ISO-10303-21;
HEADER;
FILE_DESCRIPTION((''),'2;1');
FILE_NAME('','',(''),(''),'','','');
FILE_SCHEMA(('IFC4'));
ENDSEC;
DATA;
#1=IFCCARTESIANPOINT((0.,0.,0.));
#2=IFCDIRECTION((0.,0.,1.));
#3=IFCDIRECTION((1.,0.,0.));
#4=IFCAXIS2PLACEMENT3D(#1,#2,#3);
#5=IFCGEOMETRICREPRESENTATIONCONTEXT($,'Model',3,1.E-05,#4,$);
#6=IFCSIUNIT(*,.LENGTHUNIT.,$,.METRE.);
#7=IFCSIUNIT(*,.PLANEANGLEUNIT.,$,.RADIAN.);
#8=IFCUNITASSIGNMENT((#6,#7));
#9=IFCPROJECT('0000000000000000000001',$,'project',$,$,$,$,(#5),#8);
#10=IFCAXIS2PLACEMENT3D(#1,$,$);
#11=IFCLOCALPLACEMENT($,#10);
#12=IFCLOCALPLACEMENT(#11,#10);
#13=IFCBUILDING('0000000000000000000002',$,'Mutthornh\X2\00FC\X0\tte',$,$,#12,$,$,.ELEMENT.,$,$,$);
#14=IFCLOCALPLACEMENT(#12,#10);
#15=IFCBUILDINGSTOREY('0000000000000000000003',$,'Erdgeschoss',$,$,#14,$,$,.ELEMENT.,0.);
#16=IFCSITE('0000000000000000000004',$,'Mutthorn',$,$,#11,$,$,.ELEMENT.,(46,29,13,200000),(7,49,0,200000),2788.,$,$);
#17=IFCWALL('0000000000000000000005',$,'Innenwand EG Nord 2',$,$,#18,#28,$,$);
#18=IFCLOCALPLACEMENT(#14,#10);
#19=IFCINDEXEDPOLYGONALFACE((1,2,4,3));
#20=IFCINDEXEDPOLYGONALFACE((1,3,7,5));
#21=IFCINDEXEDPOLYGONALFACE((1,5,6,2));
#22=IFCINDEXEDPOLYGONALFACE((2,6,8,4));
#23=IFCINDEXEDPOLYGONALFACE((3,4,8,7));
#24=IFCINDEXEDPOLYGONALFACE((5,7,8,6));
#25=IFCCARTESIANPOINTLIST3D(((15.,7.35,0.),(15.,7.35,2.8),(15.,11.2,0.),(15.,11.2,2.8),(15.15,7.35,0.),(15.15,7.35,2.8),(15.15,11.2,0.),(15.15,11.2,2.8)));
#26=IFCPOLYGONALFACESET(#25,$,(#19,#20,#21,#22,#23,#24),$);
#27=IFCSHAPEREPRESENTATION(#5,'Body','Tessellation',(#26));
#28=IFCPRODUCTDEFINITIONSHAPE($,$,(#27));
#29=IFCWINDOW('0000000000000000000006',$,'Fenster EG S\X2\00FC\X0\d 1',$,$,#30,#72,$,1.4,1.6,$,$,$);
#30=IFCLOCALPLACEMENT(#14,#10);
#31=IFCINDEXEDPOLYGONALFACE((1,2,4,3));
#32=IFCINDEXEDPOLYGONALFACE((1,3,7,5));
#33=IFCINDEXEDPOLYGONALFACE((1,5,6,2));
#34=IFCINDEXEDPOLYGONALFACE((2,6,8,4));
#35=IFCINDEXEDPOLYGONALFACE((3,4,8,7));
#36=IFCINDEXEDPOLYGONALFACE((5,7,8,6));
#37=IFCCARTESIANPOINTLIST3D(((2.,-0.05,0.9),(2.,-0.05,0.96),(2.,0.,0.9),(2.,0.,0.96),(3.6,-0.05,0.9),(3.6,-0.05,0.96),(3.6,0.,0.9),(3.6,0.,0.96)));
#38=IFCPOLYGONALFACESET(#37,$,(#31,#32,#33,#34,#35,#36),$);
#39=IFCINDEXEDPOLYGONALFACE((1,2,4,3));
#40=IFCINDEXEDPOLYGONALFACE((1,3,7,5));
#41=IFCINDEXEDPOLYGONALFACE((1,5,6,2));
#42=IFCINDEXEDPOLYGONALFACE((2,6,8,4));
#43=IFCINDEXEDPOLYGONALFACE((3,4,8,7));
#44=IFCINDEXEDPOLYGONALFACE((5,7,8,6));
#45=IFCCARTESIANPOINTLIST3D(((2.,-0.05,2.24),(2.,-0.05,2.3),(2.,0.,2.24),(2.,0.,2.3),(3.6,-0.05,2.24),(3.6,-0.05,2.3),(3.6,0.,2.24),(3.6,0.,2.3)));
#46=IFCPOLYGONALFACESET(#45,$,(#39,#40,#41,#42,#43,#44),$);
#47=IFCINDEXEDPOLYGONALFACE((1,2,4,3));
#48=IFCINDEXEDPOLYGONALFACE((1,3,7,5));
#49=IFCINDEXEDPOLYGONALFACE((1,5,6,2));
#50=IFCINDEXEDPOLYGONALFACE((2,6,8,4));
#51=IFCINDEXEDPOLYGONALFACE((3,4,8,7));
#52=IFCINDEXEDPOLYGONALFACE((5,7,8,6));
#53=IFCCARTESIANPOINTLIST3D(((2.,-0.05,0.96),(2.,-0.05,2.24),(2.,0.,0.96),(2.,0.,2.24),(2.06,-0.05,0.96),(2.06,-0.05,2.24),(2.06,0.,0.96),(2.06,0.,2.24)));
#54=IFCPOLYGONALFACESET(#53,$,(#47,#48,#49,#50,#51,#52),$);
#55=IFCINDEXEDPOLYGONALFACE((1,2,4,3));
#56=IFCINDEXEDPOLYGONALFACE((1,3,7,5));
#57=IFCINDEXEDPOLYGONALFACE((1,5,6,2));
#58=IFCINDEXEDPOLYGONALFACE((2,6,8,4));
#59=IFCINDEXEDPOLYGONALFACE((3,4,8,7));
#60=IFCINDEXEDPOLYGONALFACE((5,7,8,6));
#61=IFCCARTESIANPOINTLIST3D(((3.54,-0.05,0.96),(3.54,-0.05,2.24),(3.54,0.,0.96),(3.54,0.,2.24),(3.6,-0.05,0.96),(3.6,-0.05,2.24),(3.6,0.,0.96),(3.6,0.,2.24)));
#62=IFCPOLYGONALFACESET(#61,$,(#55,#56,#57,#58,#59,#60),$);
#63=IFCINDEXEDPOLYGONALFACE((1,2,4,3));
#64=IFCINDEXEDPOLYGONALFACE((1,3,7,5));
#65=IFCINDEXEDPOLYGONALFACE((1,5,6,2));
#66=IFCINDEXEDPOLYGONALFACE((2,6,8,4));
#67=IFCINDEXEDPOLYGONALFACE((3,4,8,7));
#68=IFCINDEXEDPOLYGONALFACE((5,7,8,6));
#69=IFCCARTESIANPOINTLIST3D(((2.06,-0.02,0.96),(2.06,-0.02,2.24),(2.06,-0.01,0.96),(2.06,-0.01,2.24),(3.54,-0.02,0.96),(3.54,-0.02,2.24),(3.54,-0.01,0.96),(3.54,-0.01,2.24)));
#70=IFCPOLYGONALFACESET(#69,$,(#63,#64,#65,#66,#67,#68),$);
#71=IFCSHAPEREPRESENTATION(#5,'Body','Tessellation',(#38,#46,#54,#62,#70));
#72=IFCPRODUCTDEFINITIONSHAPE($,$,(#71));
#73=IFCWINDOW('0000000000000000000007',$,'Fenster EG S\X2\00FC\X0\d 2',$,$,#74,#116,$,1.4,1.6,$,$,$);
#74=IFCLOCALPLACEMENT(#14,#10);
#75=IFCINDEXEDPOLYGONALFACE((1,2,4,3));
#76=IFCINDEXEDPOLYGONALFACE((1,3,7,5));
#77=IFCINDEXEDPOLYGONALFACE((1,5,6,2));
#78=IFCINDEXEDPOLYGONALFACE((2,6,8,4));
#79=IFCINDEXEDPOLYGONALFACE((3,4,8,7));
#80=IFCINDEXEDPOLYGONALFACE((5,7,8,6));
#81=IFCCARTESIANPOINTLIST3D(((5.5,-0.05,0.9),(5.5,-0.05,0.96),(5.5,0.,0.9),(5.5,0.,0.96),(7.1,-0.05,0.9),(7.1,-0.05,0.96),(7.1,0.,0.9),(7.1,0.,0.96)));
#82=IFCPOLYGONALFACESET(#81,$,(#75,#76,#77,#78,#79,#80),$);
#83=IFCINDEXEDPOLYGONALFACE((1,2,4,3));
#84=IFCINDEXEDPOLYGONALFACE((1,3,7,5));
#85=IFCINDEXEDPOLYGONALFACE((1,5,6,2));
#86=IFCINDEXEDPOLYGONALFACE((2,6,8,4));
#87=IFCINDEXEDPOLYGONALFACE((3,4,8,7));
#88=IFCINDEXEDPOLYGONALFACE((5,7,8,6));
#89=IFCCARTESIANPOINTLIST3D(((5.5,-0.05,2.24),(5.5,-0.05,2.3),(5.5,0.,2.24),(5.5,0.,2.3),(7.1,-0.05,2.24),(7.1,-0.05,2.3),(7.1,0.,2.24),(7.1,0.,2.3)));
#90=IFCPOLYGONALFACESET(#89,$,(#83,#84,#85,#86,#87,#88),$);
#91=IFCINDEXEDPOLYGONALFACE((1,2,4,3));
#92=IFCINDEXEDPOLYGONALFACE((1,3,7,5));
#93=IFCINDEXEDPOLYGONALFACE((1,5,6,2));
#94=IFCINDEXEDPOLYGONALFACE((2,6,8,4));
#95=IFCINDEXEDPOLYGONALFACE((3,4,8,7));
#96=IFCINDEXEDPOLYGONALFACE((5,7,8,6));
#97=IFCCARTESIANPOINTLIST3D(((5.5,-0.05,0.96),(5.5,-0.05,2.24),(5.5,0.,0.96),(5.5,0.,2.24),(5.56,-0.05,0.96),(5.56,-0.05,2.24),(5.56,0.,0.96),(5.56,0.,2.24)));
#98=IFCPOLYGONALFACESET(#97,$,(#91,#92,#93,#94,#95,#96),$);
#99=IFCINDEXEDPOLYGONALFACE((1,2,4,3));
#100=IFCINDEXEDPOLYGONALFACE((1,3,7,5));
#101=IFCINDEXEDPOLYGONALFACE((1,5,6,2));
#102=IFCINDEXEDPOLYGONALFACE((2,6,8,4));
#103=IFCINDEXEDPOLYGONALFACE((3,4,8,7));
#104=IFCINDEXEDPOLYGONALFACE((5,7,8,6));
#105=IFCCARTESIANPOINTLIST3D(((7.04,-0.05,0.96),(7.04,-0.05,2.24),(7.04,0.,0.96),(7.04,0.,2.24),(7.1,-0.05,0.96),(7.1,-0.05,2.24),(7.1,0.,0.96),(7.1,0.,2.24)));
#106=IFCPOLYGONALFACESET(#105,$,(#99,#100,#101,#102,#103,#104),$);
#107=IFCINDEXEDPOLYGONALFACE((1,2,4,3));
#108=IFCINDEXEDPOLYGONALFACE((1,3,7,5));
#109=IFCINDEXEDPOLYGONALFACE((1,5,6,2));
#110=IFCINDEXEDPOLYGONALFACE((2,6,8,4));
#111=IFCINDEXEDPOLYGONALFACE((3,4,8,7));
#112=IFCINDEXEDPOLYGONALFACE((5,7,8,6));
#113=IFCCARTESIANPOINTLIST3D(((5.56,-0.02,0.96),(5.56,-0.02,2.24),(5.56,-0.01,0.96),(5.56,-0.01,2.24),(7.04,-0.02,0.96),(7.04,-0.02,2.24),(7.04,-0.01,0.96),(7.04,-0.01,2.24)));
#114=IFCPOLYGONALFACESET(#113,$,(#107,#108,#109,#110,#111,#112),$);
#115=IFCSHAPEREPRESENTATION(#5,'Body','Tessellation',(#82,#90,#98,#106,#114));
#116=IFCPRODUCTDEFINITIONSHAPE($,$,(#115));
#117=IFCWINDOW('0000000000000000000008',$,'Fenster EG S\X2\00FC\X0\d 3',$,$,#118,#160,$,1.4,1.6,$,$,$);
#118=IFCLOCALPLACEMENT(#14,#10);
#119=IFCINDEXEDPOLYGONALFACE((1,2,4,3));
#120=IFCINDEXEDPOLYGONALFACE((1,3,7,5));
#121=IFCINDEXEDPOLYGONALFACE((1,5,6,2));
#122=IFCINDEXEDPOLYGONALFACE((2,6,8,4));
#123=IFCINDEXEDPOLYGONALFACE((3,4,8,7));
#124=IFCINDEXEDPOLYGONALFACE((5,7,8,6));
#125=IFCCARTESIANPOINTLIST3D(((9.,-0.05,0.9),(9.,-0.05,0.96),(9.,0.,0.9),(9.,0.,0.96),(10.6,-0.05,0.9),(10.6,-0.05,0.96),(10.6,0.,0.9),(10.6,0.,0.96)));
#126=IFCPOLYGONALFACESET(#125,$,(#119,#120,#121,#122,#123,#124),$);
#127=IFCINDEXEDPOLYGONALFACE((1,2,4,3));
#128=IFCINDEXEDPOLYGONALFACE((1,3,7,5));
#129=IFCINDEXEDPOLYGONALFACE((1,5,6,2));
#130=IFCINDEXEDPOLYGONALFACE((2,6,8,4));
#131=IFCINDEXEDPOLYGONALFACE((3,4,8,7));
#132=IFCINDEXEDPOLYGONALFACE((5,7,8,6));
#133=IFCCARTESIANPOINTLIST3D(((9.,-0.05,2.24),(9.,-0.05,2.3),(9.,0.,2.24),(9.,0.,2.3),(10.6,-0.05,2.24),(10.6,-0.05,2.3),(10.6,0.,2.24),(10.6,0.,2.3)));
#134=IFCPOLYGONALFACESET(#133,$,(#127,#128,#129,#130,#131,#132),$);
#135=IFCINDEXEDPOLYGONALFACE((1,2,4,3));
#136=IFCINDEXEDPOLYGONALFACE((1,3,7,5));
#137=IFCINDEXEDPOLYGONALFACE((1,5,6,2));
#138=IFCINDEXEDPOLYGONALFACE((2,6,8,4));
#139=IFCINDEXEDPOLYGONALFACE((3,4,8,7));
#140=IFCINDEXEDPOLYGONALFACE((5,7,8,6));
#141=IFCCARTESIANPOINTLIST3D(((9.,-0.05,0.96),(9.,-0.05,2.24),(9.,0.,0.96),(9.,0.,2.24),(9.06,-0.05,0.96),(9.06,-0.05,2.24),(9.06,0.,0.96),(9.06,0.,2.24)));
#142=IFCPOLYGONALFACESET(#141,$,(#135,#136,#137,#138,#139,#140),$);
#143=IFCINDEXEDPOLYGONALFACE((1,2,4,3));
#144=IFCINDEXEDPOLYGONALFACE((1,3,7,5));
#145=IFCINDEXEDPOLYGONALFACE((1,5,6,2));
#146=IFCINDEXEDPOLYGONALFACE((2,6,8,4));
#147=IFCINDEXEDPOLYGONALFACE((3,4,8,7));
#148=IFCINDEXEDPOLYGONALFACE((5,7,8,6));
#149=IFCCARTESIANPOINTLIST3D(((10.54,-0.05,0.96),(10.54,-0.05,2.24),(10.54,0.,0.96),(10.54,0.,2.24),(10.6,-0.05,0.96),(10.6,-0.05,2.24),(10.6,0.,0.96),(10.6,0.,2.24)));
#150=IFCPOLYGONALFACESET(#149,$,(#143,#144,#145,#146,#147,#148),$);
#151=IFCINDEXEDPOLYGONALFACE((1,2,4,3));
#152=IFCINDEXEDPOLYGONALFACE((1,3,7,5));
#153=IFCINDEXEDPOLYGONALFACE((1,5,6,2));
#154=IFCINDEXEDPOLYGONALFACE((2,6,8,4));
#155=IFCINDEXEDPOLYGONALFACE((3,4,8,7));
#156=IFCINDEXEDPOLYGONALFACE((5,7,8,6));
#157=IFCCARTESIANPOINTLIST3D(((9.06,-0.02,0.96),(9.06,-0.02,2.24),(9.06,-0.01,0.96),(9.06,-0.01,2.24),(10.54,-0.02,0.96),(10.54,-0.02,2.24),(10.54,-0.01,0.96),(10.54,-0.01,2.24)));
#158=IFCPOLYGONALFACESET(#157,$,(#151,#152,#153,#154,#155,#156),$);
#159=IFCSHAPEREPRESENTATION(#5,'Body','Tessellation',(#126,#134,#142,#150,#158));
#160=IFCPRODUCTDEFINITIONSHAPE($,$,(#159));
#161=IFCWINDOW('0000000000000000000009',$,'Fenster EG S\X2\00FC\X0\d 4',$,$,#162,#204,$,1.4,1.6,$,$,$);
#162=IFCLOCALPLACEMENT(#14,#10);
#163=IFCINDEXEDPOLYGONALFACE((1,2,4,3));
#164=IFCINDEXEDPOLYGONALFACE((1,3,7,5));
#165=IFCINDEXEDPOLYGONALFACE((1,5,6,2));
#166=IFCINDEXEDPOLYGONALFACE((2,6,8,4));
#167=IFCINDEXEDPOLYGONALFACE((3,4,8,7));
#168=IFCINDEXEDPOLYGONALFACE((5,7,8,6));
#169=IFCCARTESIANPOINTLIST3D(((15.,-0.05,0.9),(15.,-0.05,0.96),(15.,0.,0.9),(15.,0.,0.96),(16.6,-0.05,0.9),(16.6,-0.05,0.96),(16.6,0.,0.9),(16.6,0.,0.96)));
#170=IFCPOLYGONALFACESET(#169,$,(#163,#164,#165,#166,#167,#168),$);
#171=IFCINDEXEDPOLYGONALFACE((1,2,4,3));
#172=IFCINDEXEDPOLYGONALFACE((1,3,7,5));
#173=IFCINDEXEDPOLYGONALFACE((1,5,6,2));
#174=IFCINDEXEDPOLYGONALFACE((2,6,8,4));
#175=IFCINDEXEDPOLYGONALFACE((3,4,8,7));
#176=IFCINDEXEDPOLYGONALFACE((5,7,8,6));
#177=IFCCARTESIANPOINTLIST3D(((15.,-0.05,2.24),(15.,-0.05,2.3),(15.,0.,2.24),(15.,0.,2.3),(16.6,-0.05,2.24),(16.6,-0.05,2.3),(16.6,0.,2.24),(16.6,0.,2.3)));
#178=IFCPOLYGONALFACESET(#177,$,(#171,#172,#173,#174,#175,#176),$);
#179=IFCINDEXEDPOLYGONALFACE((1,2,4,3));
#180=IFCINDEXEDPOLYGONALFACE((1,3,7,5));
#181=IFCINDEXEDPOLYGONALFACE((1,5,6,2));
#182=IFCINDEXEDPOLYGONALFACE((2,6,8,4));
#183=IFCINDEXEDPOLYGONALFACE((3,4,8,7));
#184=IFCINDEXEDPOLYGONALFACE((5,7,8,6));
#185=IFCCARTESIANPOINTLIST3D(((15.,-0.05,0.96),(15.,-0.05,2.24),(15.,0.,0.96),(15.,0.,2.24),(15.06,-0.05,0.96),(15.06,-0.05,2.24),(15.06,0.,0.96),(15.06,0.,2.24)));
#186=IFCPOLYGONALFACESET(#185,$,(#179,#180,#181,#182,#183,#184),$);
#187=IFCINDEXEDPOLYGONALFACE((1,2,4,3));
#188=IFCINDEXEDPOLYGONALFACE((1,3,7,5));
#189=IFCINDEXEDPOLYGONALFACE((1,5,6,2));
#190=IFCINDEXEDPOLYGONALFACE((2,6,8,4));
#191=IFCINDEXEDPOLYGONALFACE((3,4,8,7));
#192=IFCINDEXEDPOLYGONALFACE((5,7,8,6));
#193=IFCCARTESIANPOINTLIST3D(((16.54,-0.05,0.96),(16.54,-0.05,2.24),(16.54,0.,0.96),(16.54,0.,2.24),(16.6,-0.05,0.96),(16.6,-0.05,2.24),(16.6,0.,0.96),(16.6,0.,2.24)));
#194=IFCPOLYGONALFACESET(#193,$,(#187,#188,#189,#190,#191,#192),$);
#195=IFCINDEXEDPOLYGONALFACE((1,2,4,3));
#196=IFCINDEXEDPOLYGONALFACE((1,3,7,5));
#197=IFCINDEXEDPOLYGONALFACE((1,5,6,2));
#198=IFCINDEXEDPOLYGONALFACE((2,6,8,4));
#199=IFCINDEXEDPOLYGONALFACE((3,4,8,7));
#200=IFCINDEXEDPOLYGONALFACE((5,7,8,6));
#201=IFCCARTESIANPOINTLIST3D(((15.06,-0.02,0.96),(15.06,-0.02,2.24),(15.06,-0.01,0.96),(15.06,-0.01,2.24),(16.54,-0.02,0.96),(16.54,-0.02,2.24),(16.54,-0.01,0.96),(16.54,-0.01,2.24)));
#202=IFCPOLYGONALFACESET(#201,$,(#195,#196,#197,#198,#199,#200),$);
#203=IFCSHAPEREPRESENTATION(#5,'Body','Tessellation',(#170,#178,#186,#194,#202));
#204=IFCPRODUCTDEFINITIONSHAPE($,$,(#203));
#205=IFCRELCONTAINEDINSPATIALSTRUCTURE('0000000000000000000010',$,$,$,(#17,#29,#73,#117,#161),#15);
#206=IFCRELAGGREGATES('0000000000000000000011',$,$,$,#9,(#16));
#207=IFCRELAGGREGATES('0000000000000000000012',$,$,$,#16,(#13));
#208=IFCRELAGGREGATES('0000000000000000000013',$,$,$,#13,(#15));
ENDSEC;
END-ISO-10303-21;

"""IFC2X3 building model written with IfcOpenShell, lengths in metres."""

from ifc_helpers import new_model, si_unit, frame, frame_2d, origin, origin_with_axes, place, context, project, spatial, rectangle, extrude, element, save


model = new_model("IFC2X3")

# Units and contexts
model_context = context("Model", 3, precision=1e-05, world=origin_with_axes())
ifc_project = project(units=[si_unit("LENGTHUNIT", "METRE"), si_unit("PLANEANGLEUNIT", "RADIAN")], contexts=[model_context])

# Site, building, storey
site_placement = place(None, origin())
site = spatial("IfcSite", under=ifc_project, at=site_placement, Name="Mutthorn", CompositionType="ELEMENT", RefLatitude=(46, 29, 13, 200000), RefLongitude=(7, 49, 0, 200000), RefElevation=2788.0)
building_placement = place(site_placement, origin())
building = spatial("IfcBuilding", under=site, at=building_placement, Name="Mutthornhütte", CompositionType="ELEMENT")
storey_placement = place(building_placement, origin())
storey = spatial("IfcBuildingStorey", under=building, at=storey_placement, Name="Erdgeschoss", CompositionType="ELEMENT", Elevation=0.0)

# Wall
wall_1_placement = place(storey_placement, origin())
element("IfcWall", 1, at=wall_1_placement, inside=storey, Name="Innenwand EG Nord 2", context=model_context, shape_type="SweptSolid", body=[
    extrude(rectangle(XDim=0.15, YDim=3.85, at=frame_2d((0.075, 1.925))), frame((15.0, 7.35, 0.0)), (0.0, 0.0, 1.0), 2.8),
])

# Windows
window_1_placement = place(storey_placement, origin())
element("IfcWindow", 2, at=window_1_placement, inside=storey, Name="Fenster EG Süd 1", OverallHeight=1.4, OverallWidth=1.6, context=model_context, shape_type="SweptSolid", body=[
    extrude(rectangle(XDim=1.6, YDim=0.05, at=frame_2d((0.8, 0.025))), frame((2.0, -0.05, 0.9)), (0.0, 0.0, 1.0), 0.06),
    extrude(rectangle(XDim=1.6, YDim=0.05, at=frame_2d((0.8, 0.025))), frame((2.0, -0.05, 2.24)), (0.0, 0.0, 1.0), 0.06),
    extrude(rectangle(XDim=0.06, YDim=0.05, at=frame_2d((0.03, 0.025))), frame((2.0, -0.05, 0.96)), (0.0, 0.0, 1.0), 1.28),
    extrude(rectangle(XDim=0.06, YDim=0.05, at=frame_2d((0.03, 0.025))), frame((3.54, -0.05, 0.96)), (0.0, 0.0, 1.0), 1.28),
    extrude(rectangle(XDim=1.48, YDim=0.01, at=frame_2d((0.74, 0.005))), frame((2.06, -0.02, 0.96)), (0.0, 0.0, 1.0), 1.28),
])
window_2_placement = place(storey_placement, origin())
element("IfcWindow", 3, at=window_2_placement, inside=storey, Name="Fenster EG Süd 2", OverallHeight=1.4, OverallWidth=1.6, context=model_context, shape_type="SweptSolid", body=[
    extrude(rectangle(XDim=1.6, YDim=0.05, at=frame_2d((0.8, 0.025))), frame((5.5, -0.05, 0.9)), (0.0, 0.0, 1.0), 0.06),
    extrude(rectangle(XDim=1.6, YDim=0.05, at=frame_2d((0.8, 0.025))), frame((5.5, -0.05, 2.24)), (0.0, 0.0, 1.0), 0.06),
    extrude(rectangle(XDim=0.06, YDim=0.05, at=frame_2d((0.03, 0.025))), frame((5.5, -0.05, 0.96)), (0.0, 0.0, 1.0), 1.28),
    extrude(rectangle(XDim=0.06, YDim=0.05, at=frame_2d((0.03, 0.025))), frame((7.04, -0.05, 0.96)), (0.0, 0.0, 1.0), 1.28),
    extrude(rectangle(XDim=1.48, YDim=0.01, at=frame_2d((0.74, 0.005))), frame((5.56, -0.02, 0.96)), (0.0, 0.0, 1.0), 1.28),
])
window_3_placement = place(storey_placement, origin())
element("IfcWindow", 4, at=window_3_placement, inside=storey, Name="Fenster EG Süd 3", OverallHeight=1.4, OverallWidth=1.6, context=model_context, shape_type="SweptSolid", body=[
    extrude(rectangle(XDim=1.6, YDim=0.05, at=frame_2d((0.8, 0.025))), frame((9.0, -0.05, 0.9)), (0.0, 0.0, 1.0), 0.06),
    extrude(rectangle(XDim=1.6, YDim=0.05, at=frame_2d((0.8, 0.025))), frame((9.0, -0.05, 2.24)), (0.0, 0.0, 1.0), 0.06),
    extrude(rectangle(XDim=0.06, YDim=0.05, at=frame_2d((0.03, 0.025))), frame((9.0, -0.05, 0.96)), (0.0, 0.0, 1.0), 1.28),
    extrude(rectangle(XDim=0.06, YDim=0.05, at=frame_2d((0.03, 0.025))), frame((10.54, -0.05, 0.96)), (0.0, 0.0, 1.0), 1.28),
    extrude(rectangle(XDim=1.48, YDim=0.01, at=frame_2d((0.74, 0.005))), frame((9.06, -0.02, 0.96)), (0.0, 0.0, 1.0), 1.28),
])
window_4_placement = place(storey_placement, origin())
element("IfcWindow", 5, at=window_4_placement, inside=storey, Name="Fenster EG Süd 4", OverallHeight=1.4, OverallWidth=1.6, context=model_context, shape_type="SweptSolid", body=[
    extrude(rectangle(XDim=1.6, YDim=0.05, at=frame_2d((0.8, 0.025))), frame((15.0, -0.05, 0.9)), (0.0, 0.0, 1.0), 0.06),
    extrude(rectangle(XDim=1.6, YDim=0.05, at=frame_2d((0.8, 0.025))), frame((15.0, -0.05, 2.24)), (0.0, 0.0, 1.0), 0.06),
    extrude(rectangle(XDim=0.06, YDim=0.05, at=frame_2d((0.03, 0.025))), frame((15.0, -0.05, 0.96)), (0.0, 0.0, 1.0), 1.28),
    extrude(rectangle(XDim=0.06, YDim=0.05, at=frame_2d((0.03, 0.025))), frame((16.54, -0.05, 0.96)), (0.0, 0.0, 1.0), 1.28),
    extrude(rectangle(XDim=1.48, YDim=0.01, at=frame_2d((0.74, 0.005))), frame((15.06, -0.02, 0.96)), (0.0, 0.0, 1.0), 1.28),
])

save(model, "model.ifc")
